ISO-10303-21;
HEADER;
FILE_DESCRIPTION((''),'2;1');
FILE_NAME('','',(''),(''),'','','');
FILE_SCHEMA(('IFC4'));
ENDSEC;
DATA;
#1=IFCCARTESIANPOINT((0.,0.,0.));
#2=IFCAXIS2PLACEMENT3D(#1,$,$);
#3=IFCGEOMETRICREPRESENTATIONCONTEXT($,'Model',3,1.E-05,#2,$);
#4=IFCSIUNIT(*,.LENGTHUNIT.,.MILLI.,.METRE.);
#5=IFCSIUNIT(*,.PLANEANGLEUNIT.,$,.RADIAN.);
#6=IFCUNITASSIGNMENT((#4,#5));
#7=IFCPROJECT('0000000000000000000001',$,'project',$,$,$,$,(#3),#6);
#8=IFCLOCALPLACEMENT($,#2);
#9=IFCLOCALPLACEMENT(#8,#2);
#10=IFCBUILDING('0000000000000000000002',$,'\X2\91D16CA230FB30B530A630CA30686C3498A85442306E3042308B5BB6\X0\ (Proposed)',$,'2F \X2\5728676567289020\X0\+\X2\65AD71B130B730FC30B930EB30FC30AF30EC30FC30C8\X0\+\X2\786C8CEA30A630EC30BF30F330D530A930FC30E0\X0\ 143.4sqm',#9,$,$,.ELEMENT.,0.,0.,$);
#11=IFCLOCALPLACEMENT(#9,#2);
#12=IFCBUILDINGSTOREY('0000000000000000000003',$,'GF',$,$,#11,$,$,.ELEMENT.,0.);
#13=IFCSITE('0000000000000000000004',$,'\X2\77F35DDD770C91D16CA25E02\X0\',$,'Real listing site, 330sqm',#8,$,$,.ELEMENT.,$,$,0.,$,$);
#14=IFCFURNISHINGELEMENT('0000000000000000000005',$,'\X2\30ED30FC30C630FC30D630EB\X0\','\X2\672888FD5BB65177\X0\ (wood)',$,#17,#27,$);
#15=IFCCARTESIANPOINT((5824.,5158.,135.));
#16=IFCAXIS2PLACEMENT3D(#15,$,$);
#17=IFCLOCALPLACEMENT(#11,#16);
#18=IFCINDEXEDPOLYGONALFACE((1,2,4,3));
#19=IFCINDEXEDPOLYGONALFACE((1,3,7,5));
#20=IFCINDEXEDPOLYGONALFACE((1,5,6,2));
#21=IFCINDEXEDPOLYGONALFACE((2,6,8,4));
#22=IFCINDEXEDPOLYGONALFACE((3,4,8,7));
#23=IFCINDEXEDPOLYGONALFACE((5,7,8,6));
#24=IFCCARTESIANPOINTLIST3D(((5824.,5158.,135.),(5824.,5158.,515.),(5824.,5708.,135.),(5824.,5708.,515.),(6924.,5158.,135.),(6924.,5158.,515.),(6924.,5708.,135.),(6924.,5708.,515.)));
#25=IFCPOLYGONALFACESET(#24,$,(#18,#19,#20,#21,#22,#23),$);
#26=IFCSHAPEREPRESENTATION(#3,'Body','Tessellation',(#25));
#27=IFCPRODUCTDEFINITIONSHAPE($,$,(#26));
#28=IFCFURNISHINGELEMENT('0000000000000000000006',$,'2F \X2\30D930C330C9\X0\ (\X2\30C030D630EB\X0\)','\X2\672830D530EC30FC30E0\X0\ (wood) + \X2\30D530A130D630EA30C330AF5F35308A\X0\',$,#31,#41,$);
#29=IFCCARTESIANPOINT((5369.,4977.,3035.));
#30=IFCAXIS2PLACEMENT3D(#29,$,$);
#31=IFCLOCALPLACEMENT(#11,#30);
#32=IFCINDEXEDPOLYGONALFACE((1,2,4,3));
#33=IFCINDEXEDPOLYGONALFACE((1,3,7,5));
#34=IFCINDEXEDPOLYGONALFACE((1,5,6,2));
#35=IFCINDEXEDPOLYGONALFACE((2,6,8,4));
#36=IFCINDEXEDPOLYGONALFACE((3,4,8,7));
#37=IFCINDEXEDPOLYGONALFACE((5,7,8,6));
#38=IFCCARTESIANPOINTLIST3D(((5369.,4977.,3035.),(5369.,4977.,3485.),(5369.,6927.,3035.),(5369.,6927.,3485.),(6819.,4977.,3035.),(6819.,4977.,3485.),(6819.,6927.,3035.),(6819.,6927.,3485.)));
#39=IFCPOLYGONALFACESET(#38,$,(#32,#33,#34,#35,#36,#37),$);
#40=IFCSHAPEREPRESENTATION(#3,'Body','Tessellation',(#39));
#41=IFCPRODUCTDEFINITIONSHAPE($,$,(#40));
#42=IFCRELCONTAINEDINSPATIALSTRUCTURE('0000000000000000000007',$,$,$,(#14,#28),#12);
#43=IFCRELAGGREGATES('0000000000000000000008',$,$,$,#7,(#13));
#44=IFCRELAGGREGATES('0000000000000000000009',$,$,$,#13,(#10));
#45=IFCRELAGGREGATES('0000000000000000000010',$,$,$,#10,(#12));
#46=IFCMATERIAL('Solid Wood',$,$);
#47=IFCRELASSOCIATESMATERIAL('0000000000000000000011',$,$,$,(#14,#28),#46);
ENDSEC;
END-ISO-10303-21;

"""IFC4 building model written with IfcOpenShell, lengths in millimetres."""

from ifc_helpers import new_model, si_unit, frame, frame_2d, origin, place, context, project, spatial, rectangle, extrude, material, element, save


model = new_model("IFC4")

# Units and contexts
model_context = context("Model", 3, precision=1e-05, world=origin())
ifc_project = project(units=[si_unit("LENGTHUNIT", "METRE", prefix="MILLI"), si_unit("PLANEANGLEUNIT", "RADIAN")], contexts=[model_context])

# Site, building, storey
site_placement = place(None, origin())
site = spatial("IfcSite", under=ifc_project, at=site_placement, Name="石川県金沢市", ObjectType="Real listing site, 330sqm", CompositionType="ELEMENT", RefElevation=0.0)
building_placement = place(site_placement, origin())
building = spatial("IfcBuilding", under=site, at=building_placement, Name="金沢・サウナと水風呂のある家 (Proposed)", ObjectType="2F 在来木造+断熱シースルークレート+硬質ウレタンフォーム 143.4sqm", CompositionType="ELEMENT", ElevationOfRefHeight=0.0, ElevationOfTerrain=0.0)
storey_placement = place(building_placement, origin())
storey = spatial("IfcBuildingStorey", under=building, at=storey_placement, Name="GF", CompositionType="ELEMENT", Elevation=0.0)

# Shared definitions
ifc_material_1 = material(Name="Solid Wood")

# Furnishing elements
furnishing_1_placement = place(storey_placement, frame((5824.0, 5158.0, 135.0)))
element("IfcFurnishingElement", 1, at=furnishing_1_placement, inside=storey, material=ifc_material_1, Name="ローテーブル", Description="木製家具 (wood)", context=model_context, shape_type="SweptSolid", body=[
    extrude(rectangle(XDim=1100.0, YDim=550.0, at=frame_2d((550.0, 275.0))), frame((5824.0, 5158.0, 135.0)), (0.0, 0.0, 1.0), 380.0),
])
furnishing_2_placement = place(storey_placement, frame((5369.0, 4977.0, 3035.0)))
element("IfcFurnishingElement", 2, at=furnishing_2_placement, inside=storey, material=ifc_material_1, Name="2F ベッド (ダブル)", Description="木フレーム (wood) + ファブリック張り", context=model_context, shape_type="SweptSolid", body=[
    extrude(rectangle(XDim=1450.0, YDim=1950.0, at=frame_2d((725.0, 975.0))), frame((5369.0, 4977.0, 3035.0)), (0.0, 0.0, 1.0), 450.0),
])

save(model, "model.ifc")
